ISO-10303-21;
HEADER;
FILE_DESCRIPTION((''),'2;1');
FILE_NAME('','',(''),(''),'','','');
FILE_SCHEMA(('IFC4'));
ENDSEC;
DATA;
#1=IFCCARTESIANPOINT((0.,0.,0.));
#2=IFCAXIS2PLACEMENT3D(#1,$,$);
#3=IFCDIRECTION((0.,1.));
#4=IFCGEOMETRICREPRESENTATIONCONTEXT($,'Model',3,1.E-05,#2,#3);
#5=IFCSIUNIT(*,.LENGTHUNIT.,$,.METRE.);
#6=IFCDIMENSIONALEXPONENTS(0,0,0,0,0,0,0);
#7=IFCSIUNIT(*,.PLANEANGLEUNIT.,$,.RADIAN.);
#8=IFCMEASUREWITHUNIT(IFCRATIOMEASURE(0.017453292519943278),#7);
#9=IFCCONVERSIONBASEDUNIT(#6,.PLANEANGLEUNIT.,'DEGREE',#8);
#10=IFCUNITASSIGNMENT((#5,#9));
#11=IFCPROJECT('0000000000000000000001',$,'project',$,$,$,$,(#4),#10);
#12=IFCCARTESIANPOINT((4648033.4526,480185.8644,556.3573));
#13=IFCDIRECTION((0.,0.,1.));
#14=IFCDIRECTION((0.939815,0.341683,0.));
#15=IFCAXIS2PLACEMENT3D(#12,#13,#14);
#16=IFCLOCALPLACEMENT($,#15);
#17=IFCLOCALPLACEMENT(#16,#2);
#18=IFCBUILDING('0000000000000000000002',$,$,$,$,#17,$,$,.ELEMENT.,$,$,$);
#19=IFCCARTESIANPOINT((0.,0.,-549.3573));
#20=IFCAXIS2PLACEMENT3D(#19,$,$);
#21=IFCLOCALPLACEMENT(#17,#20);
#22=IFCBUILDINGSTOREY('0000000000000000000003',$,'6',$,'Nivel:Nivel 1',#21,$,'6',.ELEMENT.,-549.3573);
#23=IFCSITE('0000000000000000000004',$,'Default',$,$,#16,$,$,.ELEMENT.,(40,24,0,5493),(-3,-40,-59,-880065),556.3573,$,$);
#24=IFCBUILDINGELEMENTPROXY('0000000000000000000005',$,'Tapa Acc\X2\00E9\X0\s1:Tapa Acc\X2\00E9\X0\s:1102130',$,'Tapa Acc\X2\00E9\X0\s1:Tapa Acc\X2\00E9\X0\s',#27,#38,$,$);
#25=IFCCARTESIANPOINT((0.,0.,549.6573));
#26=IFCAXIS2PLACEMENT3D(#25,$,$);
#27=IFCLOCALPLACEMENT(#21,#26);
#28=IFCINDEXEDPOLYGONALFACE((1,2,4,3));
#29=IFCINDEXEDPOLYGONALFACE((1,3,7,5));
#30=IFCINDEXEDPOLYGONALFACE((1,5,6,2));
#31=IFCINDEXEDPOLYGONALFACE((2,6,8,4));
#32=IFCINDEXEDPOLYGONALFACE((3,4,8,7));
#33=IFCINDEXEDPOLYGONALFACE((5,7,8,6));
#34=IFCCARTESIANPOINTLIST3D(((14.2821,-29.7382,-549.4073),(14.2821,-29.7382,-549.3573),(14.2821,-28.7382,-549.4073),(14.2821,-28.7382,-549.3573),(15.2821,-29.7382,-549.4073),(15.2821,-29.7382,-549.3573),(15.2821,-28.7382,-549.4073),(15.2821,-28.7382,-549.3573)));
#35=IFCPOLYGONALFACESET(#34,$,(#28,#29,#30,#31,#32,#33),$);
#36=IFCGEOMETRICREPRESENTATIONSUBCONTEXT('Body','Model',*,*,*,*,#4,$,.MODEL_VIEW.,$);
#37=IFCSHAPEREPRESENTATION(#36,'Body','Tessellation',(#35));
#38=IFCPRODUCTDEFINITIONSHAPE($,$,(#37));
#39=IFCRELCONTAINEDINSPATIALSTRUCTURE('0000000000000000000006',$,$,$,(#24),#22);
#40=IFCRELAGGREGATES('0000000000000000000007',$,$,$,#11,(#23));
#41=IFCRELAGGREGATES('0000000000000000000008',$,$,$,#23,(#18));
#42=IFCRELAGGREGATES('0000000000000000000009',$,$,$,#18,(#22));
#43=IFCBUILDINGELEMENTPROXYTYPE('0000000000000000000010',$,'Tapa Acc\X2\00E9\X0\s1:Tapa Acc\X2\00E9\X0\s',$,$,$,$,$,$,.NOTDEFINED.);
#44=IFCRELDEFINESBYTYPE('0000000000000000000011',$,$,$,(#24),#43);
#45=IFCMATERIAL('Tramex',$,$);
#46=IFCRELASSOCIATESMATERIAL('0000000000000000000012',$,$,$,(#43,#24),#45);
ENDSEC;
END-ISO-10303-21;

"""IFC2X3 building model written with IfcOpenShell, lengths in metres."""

from ifc_helpers import new_model, entity, si_unit, converted_unit, direction, frame, origin, origin_2d_with_axis, place, context, subcontext, project, spatial, rectangle, extrude, source, transform, mapped, material, type_object, type_shapes, element, save


model = new_model("IFC2X3")

# Units and contexts
model_context = context("Model", 3, precision=1e-05, world=origin(), true_north=direction((0.0, 1.0)))
body_context = subcontext(model_context, "Body", "Model", "MODEL_VIEW")
ifc_project = project(units=[si_unit("LENGTHUNIT", "METRE"), converted_unit("PLANEANGLEUNIT", "DEGREE", entity("IfcRatioMeasure", 0.017453292519943278), si_unit("PLANEANGLEUNIT", "RADIAN"), dimensions=[0, 0, 0, 0, 0, 0, 0])], contexts=[model_context])

# Site, building, storey
site_placement = place(None, frame((4648033.4526, 480185.8644, 556.3573), z_axis=(0.0, 0.0, 1.0), x_axis=(0.939815, 0.341683, 0.0)))
site = spatial("IfcSite", under=ifc_project, at=site_placement, Name="Default", CompositionType="ELEMENT", RefLatitude=(40, 24, 0, 5493), RefLongitude=(-3, -40, -59, -880065), RefElevation=556.3573)
building_placement = place(site_placement, origin())
building = spatial("IfcBuilding", under=site, at=building_placement, CompositionType="ELEMENT")
storey_placement = place(building_placement, frame((0.0, 0.0, -549.3573)))
storey = spatial("IfcBuildingStorey", under=building, at=storey_placement, Name="6", ObjectType="Nivel:Nivel 1", LongName="6", CompositionType="ELEMENT", Elevation=-549.3573)

# Building element proxy
ifc_material_1 = material(Name="Tramex")
building_element_proxy_type = type_object("IfcBuildingElementProxyType", Name="Tapa Accés1:Tapa Accés", PredefinedType="NOTDEFINED", material=ifc_material_1)
shared_shape = source(origin(), body_context, "Body", "SweptSolid", [
    extrude(rectangle(XDim=1.0, YDim=1.0, at=origin_2d_with_axis()), frame((14.7821, -29.2382, -549.4073)), (0.0, 0.0, 1.0), 0.05),
])
type_shapes(building_element_proxy_type, [shared_shape])
proxy_placement = place(storey_placement, frame((0.0, 0.0, 549.6573)))
element("IfcBuildingElementProxy", 1, at=proxy_placement, inside=storey, type_object=building_element_proxy_type, material=ifc_material_1, Name="Tapa Accés1:Tapa Accés:1102130", ObjectType="Tapa Accés1:Tapa Accés", context=body_context, shape_type="MappedRepresentation", body=[
    mapped(shared_shape, transform((0.0, 0.0, 0.0), scale=1.0)),
])

save(model, "model.ifc")
